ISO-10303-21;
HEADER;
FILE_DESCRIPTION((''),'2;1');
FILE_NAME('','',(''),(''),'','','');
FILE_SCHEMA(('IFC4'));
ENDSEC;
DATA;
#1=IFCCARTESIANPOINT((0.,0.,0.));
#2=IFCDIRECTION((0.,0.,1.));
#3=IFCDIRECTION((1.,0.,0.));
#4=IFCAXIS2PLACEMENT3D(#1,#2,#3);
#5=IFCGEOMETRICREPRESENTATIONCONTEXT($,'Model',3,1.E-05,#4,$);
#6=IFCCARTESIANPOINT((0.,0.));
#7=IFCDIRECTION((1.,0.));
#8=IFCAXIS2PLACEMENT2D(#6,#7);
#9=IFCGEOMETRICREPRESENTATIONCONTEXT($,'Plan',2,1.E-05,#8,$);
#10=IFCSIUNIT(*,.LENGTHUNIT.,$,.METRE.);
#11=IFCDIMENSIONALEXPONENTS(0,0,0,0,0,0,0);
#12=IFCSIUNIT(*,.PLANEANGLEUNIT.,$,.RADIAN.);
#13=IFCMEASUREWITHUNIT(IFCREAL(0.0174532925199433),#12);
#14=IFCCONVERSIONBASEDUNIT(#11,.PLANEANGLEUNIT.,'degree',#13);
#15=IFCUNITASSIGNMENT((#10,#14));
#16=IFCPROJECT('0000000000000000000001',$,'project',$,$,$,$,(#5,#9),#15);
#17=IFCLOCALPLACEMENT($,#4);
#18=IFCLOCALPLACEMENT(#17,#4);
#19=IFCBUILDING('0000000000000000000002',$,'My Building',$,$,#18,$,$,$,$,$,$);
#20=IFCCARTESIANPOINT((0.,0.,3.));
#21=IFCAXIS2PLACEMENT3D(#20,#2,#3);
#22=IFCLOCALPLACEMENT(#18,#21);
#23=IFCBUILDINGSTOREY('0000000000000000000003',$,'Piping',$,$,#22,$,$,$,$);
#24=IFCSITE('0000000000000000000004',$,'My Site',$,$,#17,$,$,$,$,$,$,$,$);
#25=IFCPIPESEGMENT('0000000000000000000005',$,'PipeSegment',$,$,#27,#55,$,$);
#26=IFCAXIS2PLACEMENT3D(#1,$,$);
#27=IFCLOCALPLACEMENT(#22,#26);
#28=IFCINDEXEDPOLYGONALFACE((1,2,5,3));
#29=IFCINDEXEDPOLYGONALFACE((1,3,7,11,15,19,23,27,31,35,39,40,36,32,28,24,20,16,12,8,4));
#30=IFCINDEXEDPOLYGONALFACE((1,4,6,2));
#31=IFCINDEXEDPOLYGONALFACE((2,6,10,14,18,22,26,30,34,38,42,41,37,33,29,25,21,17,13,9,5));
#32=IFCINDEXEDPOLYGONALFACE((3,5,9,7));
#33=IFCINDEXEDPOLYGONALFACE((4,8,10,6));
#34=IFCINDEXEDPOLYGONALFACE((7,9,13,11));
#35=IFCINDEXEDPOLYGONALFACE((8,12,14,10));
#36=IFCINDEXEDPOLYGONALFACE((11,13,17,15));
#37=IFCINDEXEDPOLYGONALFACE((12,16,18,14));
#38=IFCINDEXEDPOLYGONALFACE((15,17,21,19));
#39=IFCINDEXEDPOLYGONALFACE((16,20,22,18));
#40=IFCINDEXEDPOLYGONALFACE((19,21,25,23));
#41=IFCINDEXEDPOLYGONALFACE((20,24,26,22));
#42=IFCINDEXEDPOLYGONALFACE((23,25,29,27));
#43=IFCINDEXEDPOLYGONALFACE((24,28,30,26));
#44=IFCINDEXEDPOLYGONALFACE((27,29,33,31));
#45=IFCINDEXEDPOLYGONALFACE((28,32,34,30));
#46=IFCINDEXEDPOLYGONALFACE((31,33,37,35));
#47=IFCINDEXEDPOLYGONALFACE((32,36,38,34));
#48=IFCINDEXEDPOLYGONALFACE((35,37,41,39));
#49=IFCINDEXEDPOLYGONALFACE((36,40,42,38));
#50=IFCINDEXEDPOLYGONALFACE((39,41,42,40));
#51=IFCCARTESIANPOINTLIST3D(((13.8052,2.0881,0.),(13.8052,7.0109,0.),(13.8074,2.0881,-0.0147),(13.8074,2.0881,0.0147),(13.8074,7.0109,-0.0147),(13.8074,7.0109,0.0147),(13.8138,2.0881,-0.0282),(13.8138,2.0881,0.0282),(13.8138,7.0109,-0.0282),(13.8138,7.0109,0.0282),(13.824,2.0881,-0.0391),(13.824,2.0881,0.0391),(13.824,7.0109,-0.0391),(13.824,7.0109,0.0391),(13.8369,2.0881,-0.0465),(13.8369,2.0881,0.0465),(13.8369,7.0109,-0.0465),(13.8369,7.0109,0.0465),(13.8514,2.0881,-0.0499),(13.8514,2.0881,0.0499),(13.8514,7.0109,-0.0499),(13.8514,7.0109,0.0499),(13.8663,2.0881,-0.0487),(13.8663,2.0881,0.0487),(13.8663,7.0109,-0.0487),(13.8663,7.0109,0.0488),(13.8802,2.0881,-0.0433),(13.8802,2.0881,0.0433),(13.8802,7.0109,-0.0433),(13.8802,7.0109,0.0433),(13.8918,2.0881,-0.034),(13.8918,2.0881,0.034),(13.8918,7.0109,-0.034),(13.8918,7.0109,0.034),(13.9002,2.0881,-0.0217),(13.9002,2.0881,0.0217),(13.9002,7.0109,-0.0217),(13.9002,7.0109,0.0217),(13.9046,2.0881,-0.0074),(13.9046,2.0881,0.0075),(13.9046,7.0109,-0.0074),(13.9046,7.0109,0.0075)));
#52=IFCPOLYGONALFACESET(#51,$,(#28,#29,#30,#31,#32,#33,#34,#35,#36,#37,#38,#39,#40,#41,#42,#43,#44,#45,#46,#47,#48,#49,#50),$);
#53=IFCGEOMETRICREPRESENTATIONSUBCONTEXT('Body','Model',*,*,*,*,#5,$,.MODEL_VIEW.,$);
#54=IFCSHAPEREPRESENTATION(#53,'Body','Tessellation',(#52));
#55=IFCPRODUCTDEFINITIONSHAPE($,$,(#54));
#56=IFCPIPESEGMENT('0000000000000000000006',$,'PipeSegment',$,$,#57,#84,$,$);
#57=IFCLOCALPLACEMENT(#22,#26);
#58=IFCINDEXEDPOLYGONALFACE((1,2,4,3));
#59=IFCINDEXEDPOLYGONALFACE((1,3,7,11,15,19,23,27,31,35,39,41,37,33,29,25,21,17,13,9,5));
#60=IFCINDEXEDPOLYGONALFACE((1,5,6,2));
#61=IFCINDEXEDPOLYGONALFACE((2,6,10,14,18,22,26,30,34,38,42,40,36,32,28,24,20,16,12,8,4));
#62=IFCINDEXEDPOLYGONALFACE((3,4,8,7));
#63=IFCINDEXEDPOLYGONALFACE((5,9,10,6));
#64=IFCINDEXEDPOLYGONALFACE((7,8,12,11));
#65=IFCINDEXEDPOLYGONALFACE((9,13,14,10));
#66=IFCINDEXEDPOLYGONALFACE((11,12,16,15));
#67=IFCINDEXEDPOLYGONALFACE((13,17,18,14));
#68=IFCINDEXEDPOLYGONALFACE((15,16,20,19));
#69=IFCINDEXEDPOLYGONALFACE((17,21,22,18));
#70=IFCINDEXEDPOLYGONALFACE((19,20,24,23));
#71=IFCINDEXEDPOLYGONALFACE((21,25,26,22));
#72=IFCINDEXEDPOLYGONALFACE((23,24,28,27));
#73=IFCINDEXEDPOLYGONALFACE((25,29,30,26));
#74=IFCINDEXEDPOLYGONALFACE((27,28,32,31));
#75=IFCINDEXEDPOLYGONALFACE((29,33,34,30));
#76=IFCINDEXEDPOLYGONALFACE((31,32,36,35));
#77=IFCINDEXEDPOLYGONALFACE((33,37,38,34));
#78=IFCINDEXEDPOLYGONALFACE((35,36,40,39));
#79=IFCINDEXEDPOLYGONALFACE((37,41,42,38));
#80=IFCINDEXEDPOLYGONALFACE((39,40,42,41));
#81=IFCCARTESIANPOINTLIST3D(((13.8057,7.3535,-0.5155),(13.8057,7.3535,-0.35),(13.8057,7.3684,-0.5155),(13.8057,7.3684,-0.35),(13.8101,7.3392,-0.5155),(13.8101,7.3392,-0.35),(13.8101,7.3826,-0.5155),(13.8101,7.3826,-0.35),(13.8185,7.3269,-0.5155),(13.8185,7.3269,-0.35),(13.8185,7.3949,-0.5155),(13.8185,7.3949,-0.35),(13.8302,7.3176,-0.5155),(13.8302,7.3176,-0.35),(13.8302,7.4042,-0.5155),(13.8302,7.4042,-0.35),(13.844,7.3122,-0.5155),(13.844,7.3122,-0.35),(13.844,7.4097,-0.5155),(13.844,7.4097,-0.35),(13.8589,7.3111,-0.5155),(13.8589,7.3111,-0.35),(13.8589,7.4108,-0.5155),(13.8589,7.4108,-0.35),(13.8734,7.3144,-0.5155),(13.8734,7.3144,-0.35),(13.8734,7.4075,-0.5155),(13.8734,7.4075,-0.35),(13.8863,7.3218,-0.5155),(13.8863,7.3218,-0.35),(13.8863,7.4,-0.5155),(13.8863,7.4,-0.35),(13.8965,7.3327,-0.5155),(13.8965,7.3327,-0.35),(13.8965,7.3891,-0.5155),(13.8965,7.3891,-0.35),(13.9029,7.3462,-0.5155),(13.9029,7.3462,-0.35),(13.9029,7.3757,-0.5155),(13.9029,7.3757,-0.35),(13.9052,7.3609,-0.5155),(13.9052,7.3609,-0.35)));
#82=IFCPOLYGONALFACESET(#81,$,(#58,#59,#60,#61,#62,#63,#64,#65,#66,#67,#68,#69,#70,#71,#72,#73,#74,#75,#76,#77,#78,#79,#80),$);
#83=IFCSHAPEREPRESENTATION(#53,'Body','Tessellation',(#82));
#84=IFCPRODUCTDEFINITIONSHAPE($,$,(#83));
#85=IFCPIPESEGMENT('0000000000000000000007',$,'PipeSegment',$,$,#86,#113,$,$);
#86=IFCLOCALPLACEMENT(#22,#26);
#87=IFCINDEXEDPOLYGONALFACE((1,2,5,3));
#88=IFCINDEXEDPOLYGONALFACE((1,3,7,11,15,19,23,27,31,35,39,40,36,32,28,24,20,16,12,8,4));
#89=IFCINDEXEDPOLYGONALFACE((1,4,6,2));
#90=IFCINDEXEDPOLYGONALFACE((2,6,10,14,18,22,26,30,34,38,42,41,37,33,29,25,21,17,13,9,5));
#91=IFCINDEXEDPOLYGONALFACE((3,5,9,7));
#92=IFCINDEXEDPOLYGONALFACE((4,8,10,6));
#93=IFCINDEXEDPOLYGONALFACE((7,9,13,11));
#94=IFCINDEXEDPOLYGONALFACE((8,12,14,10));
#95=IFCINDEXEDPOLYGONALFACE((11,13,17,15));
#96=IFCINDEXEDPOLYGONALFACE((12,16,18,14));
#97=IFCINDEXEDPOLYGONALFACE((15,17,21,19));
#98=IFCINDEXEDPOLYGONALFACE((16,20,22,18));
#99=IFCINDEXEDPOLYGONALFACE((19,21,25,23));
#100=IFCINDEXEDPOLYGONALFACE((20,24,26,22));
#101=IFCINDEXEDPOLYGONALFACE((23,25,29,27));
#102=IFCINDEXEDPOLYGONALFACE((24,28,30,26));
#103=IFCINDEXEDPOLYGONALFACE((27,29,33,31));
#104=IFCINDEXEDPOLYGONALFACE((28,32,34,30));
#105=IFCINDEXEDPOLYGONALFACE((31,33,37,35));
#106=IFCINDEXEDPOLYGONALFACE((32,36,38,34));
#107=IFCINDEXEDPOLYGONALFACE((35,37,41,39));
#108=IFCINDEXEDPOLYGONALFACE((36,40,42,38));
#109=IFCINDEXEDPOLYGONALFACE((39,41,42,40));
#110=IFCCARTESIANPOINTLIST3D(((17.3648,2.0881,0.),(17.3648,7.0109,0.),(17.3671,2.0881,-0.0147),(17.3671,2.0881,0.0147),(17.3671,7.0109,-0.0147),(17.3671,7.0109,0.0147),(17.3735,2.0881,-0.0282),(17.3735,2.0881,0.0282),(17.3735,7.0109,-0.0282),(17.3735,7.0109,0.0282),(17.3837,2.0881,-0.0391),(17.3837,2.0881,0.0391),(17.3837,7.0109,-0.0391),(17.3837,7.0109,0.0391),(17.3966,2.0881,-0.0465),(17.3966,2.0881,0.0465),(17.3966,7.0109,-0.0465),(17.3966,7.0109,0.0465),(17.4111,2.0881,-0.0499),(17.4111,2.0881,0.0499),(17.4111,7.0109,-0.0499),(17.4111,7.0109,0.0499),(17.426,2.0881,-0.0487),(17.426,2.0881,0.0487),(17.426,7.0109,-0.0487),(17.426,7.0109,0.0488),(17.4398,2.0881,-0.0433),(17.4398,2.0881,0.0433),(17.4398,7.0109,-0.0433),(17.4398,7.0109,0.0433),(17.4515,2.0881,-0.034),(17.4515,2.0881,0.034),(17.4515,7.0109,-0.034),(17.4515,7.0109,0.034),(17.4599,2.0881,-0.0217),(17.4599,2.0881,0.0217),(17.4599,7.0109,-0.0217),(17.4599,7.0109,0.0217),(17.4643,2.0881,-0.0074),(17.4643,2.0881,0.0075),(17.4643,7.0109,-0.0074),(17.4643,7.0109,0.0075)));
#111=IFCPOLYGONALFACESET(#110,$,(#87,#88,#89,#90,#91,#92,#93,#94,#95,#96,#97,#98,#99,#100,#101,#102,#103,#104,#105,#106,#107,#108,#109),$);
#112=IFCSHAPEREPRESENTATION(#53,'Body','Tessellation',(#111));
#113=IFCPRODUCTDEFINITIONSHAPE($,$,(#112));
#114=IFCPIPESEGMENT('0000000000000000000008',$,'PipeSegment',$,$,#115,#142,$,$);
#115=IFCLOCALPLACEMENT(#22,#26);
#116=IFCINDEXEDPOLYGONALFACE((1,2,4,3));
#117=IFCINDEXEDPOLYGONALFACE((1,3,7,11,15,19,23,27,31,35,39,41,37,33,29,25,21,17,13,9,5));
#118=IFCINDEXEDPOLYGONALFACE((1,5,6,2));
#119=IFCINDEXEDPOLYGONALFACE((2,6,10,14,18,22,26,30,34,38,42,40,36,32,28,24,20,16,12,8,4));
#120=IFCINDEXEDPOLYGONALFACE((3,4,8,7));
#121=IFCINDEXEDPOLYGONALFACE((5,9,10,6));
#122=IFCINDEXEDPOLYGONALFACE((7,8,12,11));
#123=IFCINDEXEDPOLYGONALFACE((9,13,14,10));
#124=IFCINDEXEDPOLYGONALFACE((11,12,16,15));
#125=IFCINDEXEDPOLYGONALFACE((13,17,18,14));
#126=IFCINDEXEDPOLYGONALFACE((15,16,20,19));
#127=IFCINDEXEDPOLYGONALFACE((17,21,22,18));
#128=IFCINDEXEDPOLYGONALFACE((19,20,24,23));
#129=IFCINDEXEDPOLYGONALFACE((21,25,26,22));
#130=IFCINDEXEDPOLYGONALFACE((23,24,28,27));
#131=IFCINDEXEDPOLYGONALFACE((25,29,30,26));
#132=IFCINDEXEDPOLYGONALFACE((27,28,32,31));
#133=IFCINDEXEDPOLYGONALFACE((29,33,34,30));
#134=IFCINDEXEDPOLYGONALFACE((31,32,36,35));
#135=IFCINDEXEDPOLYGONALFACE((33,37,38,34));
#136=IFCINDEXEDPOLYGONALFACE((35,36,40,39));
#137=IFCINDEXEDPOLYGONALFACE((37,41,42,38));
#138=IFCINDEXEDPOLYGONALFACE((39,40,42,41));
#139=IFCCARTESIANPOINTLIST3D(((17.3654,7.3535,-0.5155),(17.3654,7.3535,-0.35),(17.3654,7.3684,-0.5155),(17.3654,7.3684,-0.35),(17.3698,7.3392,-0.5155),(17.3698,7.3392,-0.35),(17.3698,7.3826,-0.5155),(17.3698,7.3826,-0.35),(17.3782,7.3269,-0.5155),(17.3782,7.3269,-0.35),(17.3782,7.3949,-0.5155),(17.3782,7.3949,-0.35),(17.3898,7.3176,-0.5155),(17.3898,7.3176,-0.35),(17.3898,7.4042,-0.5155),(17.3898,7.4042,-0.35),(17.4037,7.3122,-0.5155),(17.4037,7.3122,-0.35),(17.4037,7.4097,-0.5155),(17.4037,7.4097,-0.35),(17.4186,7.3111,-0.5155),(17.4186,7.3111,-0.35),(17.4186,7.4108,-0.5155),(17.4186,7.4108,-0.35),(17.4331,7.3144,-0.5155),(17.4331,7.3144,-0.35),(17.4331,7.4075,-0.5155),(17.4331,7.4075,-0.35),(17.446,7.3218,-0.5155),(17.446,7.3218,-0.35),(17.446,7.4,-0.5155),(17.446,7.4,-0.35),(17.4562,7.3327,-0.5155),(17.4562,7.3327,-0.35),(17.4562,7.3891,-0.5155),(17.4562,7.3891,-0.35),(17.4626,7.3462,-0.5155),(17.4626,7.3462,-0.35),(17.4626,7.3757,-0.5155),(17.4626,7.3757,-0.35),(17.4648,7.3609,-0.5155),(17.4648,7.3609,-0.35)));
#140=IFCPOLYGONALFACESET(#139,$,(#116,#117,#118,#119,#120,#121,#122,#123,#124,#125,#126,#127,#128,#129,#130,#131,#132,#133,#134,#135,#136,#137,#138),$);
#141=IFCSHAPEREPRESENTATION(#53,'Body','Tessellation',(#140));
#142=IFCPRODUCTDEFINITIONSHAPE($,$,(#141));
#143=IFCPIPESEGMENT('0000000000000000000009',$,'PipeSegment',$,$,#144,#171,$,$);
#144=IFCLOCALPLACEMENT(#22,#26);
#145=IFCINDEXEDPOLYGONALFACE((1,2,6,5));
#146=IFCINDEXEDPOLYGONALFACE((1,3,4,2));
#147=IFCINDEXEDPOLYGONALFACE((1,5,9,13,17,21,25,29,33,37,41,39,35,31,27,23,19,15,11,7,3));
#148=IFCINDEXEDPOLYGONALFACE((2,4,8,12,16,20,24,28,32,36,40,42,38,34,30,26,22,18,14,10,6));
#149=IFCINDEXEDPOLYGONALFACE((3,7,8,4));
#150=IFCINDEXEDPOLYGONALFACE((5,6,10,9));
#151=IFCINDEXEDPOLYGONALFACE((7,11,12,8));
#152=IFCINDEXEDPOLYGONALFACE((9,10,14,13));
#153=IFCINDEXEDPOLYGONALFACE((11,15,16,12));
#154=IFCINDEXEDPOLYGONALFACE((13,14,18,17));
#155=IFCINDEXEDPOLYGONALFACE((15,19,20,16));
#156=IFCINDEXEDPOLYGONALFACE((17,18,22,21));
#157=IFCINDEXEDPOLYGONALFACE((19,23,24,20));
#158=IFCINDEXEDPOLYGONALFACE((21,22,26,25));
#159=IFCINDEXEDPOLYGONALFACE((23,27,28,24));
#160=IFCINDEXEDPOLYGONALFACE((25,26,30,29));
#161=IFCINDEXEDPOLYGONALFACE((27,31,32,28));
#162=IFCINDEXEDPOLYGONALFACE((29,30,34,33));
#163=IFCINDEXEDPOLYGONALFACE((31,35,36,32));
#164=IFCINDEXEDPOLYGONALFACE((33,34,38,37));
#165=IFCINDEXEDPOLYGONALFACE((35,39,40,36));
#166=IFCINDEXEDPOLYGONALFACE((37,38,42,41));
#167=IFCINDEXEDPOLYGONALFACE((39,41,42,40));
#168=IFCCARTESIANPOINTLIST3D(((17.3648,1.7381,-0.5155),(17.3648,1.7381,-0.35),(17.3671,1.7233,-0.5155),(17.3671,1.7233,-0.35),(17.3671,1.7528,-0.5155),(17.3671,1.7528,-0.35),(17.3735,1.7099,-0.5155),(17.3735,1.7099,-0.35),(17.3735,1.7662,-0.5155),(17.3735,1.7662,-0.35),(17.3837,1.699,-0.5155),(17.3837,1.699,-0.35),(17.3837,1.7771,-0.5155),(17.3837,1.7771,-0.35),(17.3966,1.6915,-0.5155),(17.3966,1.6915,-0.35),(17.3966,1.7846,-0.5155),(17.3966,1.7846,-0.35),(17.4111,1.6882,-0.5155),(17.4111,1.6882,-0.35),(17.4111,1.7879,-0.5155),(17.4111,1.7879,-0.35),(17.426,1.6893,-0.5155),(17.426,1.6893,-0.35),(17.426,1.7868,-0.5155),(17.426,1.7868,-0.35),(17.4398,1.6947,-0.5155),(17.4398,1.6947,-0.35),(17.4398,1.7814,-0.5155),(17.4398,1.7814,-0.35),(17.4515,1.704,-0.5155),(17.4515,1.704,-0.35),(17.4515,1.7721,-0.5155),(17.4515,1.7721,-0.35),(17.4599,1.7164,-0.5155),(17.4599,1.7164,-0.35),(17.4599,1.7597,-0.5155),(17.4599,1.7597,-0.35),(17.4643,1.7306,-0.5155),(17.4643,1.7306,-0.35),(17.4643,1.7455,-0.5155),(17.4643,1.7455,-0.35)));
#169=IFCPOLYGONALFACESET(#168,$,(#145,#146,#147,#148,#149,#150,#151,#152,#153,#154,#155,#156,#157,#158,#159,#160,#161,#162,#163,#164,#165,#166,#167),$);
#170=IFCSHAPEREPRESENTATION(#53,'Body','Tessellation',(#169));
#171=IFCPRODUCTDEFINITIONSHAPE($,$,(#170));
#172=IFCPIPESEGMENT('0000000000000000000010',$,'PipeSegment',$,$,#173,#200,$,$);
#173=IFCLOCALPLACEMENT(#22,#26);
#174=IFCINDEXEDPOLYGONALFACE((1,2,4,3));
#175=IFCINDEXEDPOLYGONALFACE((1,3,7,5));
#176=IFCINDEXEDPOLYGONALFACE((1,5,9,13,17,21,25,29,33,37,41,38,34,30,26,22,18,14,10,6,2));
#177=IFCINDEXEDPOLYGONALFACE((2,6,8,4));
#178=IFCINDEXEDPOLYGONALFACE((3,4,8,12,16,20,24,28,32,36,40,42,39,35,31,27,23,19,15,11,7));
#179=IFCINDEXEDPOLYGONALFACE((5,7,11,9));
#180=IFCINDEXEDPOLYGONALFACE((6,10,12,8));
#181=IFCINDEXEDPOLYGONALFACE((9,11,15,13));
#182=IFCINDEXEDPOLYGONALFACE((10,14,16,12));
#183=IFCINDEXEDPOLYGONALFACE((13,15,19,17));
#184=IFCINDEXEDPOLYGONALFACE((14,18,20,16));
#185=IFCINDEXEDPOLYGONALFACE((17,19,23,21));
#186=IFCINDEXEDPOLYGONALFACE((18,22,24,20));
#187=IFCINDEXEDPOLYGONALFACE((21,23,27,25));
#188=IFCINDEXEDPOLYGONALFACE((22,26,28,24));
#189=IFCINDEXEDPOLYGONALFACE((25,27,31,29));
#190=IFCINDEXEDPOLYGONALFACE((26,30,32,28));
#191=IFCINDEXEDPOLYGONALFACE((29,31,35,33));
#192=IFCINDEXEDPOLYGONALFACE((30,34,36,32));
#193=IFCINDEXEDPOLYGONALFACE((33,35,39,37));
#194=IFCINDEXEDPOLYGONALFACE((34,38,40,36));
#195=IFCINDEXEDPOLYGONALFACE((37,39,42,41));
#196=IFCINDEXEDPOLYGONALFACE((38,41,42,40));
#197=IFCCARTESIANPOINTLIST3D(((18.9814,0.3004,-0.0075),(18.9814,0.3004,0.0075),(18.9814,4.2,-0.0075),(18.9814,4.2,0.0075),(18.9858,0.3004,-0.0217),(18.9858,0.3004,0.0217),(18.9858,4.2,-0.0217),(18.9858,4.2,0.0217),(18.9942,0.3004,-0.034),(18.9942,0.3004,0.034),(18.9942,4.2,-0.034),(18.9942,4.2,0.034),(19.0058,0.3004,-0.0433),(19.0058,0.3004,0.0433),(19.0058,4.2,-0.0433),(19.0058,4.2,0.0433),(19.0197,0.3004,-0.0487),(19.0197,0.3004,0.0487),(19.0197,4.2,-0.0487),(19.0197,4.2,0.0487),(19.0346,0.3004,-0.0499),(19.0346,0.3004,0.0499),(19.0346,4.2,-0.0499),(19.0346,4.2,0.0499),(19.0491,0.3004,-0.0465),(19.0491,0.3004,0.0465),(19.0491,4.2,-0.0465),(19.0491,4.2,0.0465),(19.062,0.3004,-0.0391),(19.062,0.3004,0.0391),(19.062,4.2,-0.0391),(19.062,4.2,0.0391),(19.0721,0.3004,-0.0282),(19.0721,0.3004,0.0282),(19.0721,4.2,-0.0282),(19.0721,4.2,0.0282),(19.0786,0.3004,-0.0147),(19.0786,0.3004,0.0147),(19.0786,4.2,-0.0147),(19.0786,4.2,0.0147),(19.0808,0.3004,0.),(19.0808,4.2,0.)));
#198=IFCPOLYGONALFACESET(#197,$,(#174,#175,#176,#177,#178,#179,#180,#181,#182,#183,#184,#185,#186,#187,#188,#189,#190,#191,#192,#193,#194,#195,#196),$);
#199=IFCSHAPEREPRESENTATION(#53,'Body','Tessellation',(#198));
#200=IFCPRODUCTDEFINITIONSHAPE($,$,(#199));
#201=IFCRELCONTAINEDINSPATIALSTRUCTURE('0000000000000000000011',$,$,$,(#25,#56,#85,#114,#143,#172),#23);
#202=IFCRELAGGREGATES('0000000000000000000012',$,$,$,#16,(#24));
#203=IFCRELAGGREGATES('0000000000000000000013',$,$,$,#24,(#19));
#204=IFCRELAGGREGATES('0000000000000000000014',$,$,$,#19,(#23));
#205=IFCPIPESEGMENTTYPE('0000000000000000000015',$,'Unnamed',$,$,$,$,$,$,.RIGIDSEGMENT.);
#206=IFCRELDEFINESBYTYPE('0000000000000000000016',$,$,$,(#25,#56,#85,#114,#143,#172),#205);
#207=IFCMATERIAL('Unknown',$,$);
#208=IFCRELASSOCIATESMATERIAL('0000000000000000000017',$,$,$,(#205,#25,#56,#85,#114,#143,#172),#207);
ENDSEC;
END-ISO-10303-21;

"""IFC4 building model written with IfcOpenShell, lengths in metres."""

from ifc_helpers import new_model, entity, si_unit, converted_unit, frame, origin_with_axes, origin_2d_with_axis, place, context, subcontext, project, spatial, circle, extrude, material, material_profile, profile_set, profile_usage, type_object, element, save


model = new_model("IFC4")

# Units and contexts
model_context = context("Model", 3, precision=1e-05, world=origin_with_axes())
plan_context = context("Plan", 2, precision=1e-05, world=origin_2d_with_axis())
body_context = subcontext(model_context, "Body", "Model", "MODEL_VIEW")
ifc_project = project(units=[si_unit("LENGTHUNIT", "METRE"), converted_unit("PLANEANGLEUNIT", "degree", entity("IfcReal", 0.0174532925199433), si_unit("PLANEANGLEUNIT", "RADIAN"), dimensions=[0, 0, 0, 0, 0, 0, 0])], contexts=[model_context, plan_context])

# Site, building, storey
site_placement = place(None, origin_with_axes())
site = spatial("IfcSite", under=ifc_project, at=site_placement, Name="My Site")
building_placement = place(site_placement, origin_with_axes())
building = spatial("IfcBuilding", under=site, at=building_placement, Name="My Building")
storey_placement = place(building_placement, frame((0.0, 0.0, 3.0), z_axis=(0.0, 0.0, 1.0), x_axis=(1.0, 0.0, 0.0)))
storey = spatial("IfcBuildingStorey", under=building, at=storey_placement, Name="Piping")

# Pipe segments
ifc_material = material(Name="Unknown")
ifc_material_profile = material_profile(ifc_material, circle(Radius=0.05))
ifc_profile_set = profile_set([ifc_material_profile])
pipe_segment_type = type_object("IfcPipeSegmentType", Name="Unnamed", PredefinedType="RIGIDSEGMENT", material=ifc_profile_set)
ifc_profile_usage_1 = profile_usage(ifc_profile_set, cardinal=5)
pipe_segment_1_placement = place(storey_placement, frame((13.8552, 2.0881, 0.0), z_axis=(0.0, 1.0, 0.0), x_axis=(-1.0, 0.0, 0.0)))
element("IfcPipeSegment", 1, at=pipe_segment_1_placement, inside=storey, type_object=pipe_segment_type, material=ifc_profile_usage_1, Name="PipeSegment", context=body_context, shape_type="SweptSolid", body=[
    extrude(circle(Radius=0.05), origin_with_axes(), (0.0, 0.0, 1.0), 4.9229),
])
ifc_profile_usage_2 = profile_usage(ifc_profile_set, cardinal=5)
pipe_segment_2_placement = place(storey_placement, frame((13.8552, 7.3609, -0.35), z_axis=(0.0, 0.0, -1.0), x_axis=(1.0, 0.0, 0.0)))
element("IfcPipeSegment", 2, at=pipe_segment_2_placement, inside=storey, type_object=pipe_segment_type, material=ifc_profile_usage_2, Name="PipeSegment", context=body_context, shape_type="SweptSolid", body=[
    extrude(circle(Radius=0.05), origin_with_axes(), (0.0, 0.0, 1.0), 0.1655),
])
ifc_profile_usage_3 = profile_usage(ifc_profile_set, cardinal=5)
pipe_segment_3_placement = place(storey_placement, frame((17.4148, 2.0881, 0.0), z_axis=(0.0, 1.0, 0.0), x_axis=(-1.0, 0.0, 0.0)))
element("IfcPipeSegment", 3, at=pipe_segment_3_placement, inside=storey, type_object=pipe_segment_type, material=ifc_profile_usage_3, Name="PipeSegment", context=body_context, shape_type="SweptSolid", body=[
    extrude(circle(Radius=0.05), origin_with_axes(), (0.0, 0.0, 1.0), 4.9229),
])
ifc_profile_usage_4 = profile_usage(ifc_profile_set, cardinal=5)
pipe_segment_4_placement = place(storey_placement, frame((17.4148, 7.3609, -0.35), z_axis=(0.0, 0.0, -1.0), x_axis=(1.0, 0.0, 0.0)))
element("IfcPipeSegment", 4, at=pipe_segment_4_placement, inside=storey, type_object=pipe_segment_type, material=ifc_profile_usage_4, Name="PipeSegment", context=body_context, shape_type="SweptSolid", body=[
    extrude(circle(Radius=0.05), origin_with_axes(), (0.0, 0.0, 1.0), 0.1655),
])
ifc_profile_usage_5 = profile_usage(ifc_profile_set, cardinal=5)
pipe_segment_5_placement = place(storey_placement, frame((17.4148, 1.7381, -0.35), z_axis=(0.0, 0.0, -1.0), x_axis=(-1.0, 0.0, 0.0)))
element("IfcPipeSegment", 5, at=pipe_segment_5_placement, inside=storey, type_object=pipe_segment_type, material=ifc_profile_usage_5, Name="PipeSegment", context=body_context, shape_type="SweptSolid", body=[
    extrude(circle(Radius=0.05), origin_with_axes(), (0.0, 0.0, 1.0), 0.1655),
])
ifc_profile_usage_6 = profile_usage(ifc_profile_set, cardinal=5)
pipe_segment_6_placement = place(storey_placement, frame((19.0308, 4.2, 0.0), z_axis=(0.0, -1.0, 0.0), x_axis=(1.0, 0.0, 0.0)))
element("IfcPipeSegment", 6, at=pipe_segment_6_placement, inside=storey, type_object=pipe_segment_type, material=ifc_profile_usage_6, Name="PipeSegment", context=body_context, shape_type="SweptSolid", body=[
    extrude(circle(Radius=0.05), origin_with_axes(), (0.0, 0.0, 1.0), 3.8996),
])

save(model, "model.ifc")
